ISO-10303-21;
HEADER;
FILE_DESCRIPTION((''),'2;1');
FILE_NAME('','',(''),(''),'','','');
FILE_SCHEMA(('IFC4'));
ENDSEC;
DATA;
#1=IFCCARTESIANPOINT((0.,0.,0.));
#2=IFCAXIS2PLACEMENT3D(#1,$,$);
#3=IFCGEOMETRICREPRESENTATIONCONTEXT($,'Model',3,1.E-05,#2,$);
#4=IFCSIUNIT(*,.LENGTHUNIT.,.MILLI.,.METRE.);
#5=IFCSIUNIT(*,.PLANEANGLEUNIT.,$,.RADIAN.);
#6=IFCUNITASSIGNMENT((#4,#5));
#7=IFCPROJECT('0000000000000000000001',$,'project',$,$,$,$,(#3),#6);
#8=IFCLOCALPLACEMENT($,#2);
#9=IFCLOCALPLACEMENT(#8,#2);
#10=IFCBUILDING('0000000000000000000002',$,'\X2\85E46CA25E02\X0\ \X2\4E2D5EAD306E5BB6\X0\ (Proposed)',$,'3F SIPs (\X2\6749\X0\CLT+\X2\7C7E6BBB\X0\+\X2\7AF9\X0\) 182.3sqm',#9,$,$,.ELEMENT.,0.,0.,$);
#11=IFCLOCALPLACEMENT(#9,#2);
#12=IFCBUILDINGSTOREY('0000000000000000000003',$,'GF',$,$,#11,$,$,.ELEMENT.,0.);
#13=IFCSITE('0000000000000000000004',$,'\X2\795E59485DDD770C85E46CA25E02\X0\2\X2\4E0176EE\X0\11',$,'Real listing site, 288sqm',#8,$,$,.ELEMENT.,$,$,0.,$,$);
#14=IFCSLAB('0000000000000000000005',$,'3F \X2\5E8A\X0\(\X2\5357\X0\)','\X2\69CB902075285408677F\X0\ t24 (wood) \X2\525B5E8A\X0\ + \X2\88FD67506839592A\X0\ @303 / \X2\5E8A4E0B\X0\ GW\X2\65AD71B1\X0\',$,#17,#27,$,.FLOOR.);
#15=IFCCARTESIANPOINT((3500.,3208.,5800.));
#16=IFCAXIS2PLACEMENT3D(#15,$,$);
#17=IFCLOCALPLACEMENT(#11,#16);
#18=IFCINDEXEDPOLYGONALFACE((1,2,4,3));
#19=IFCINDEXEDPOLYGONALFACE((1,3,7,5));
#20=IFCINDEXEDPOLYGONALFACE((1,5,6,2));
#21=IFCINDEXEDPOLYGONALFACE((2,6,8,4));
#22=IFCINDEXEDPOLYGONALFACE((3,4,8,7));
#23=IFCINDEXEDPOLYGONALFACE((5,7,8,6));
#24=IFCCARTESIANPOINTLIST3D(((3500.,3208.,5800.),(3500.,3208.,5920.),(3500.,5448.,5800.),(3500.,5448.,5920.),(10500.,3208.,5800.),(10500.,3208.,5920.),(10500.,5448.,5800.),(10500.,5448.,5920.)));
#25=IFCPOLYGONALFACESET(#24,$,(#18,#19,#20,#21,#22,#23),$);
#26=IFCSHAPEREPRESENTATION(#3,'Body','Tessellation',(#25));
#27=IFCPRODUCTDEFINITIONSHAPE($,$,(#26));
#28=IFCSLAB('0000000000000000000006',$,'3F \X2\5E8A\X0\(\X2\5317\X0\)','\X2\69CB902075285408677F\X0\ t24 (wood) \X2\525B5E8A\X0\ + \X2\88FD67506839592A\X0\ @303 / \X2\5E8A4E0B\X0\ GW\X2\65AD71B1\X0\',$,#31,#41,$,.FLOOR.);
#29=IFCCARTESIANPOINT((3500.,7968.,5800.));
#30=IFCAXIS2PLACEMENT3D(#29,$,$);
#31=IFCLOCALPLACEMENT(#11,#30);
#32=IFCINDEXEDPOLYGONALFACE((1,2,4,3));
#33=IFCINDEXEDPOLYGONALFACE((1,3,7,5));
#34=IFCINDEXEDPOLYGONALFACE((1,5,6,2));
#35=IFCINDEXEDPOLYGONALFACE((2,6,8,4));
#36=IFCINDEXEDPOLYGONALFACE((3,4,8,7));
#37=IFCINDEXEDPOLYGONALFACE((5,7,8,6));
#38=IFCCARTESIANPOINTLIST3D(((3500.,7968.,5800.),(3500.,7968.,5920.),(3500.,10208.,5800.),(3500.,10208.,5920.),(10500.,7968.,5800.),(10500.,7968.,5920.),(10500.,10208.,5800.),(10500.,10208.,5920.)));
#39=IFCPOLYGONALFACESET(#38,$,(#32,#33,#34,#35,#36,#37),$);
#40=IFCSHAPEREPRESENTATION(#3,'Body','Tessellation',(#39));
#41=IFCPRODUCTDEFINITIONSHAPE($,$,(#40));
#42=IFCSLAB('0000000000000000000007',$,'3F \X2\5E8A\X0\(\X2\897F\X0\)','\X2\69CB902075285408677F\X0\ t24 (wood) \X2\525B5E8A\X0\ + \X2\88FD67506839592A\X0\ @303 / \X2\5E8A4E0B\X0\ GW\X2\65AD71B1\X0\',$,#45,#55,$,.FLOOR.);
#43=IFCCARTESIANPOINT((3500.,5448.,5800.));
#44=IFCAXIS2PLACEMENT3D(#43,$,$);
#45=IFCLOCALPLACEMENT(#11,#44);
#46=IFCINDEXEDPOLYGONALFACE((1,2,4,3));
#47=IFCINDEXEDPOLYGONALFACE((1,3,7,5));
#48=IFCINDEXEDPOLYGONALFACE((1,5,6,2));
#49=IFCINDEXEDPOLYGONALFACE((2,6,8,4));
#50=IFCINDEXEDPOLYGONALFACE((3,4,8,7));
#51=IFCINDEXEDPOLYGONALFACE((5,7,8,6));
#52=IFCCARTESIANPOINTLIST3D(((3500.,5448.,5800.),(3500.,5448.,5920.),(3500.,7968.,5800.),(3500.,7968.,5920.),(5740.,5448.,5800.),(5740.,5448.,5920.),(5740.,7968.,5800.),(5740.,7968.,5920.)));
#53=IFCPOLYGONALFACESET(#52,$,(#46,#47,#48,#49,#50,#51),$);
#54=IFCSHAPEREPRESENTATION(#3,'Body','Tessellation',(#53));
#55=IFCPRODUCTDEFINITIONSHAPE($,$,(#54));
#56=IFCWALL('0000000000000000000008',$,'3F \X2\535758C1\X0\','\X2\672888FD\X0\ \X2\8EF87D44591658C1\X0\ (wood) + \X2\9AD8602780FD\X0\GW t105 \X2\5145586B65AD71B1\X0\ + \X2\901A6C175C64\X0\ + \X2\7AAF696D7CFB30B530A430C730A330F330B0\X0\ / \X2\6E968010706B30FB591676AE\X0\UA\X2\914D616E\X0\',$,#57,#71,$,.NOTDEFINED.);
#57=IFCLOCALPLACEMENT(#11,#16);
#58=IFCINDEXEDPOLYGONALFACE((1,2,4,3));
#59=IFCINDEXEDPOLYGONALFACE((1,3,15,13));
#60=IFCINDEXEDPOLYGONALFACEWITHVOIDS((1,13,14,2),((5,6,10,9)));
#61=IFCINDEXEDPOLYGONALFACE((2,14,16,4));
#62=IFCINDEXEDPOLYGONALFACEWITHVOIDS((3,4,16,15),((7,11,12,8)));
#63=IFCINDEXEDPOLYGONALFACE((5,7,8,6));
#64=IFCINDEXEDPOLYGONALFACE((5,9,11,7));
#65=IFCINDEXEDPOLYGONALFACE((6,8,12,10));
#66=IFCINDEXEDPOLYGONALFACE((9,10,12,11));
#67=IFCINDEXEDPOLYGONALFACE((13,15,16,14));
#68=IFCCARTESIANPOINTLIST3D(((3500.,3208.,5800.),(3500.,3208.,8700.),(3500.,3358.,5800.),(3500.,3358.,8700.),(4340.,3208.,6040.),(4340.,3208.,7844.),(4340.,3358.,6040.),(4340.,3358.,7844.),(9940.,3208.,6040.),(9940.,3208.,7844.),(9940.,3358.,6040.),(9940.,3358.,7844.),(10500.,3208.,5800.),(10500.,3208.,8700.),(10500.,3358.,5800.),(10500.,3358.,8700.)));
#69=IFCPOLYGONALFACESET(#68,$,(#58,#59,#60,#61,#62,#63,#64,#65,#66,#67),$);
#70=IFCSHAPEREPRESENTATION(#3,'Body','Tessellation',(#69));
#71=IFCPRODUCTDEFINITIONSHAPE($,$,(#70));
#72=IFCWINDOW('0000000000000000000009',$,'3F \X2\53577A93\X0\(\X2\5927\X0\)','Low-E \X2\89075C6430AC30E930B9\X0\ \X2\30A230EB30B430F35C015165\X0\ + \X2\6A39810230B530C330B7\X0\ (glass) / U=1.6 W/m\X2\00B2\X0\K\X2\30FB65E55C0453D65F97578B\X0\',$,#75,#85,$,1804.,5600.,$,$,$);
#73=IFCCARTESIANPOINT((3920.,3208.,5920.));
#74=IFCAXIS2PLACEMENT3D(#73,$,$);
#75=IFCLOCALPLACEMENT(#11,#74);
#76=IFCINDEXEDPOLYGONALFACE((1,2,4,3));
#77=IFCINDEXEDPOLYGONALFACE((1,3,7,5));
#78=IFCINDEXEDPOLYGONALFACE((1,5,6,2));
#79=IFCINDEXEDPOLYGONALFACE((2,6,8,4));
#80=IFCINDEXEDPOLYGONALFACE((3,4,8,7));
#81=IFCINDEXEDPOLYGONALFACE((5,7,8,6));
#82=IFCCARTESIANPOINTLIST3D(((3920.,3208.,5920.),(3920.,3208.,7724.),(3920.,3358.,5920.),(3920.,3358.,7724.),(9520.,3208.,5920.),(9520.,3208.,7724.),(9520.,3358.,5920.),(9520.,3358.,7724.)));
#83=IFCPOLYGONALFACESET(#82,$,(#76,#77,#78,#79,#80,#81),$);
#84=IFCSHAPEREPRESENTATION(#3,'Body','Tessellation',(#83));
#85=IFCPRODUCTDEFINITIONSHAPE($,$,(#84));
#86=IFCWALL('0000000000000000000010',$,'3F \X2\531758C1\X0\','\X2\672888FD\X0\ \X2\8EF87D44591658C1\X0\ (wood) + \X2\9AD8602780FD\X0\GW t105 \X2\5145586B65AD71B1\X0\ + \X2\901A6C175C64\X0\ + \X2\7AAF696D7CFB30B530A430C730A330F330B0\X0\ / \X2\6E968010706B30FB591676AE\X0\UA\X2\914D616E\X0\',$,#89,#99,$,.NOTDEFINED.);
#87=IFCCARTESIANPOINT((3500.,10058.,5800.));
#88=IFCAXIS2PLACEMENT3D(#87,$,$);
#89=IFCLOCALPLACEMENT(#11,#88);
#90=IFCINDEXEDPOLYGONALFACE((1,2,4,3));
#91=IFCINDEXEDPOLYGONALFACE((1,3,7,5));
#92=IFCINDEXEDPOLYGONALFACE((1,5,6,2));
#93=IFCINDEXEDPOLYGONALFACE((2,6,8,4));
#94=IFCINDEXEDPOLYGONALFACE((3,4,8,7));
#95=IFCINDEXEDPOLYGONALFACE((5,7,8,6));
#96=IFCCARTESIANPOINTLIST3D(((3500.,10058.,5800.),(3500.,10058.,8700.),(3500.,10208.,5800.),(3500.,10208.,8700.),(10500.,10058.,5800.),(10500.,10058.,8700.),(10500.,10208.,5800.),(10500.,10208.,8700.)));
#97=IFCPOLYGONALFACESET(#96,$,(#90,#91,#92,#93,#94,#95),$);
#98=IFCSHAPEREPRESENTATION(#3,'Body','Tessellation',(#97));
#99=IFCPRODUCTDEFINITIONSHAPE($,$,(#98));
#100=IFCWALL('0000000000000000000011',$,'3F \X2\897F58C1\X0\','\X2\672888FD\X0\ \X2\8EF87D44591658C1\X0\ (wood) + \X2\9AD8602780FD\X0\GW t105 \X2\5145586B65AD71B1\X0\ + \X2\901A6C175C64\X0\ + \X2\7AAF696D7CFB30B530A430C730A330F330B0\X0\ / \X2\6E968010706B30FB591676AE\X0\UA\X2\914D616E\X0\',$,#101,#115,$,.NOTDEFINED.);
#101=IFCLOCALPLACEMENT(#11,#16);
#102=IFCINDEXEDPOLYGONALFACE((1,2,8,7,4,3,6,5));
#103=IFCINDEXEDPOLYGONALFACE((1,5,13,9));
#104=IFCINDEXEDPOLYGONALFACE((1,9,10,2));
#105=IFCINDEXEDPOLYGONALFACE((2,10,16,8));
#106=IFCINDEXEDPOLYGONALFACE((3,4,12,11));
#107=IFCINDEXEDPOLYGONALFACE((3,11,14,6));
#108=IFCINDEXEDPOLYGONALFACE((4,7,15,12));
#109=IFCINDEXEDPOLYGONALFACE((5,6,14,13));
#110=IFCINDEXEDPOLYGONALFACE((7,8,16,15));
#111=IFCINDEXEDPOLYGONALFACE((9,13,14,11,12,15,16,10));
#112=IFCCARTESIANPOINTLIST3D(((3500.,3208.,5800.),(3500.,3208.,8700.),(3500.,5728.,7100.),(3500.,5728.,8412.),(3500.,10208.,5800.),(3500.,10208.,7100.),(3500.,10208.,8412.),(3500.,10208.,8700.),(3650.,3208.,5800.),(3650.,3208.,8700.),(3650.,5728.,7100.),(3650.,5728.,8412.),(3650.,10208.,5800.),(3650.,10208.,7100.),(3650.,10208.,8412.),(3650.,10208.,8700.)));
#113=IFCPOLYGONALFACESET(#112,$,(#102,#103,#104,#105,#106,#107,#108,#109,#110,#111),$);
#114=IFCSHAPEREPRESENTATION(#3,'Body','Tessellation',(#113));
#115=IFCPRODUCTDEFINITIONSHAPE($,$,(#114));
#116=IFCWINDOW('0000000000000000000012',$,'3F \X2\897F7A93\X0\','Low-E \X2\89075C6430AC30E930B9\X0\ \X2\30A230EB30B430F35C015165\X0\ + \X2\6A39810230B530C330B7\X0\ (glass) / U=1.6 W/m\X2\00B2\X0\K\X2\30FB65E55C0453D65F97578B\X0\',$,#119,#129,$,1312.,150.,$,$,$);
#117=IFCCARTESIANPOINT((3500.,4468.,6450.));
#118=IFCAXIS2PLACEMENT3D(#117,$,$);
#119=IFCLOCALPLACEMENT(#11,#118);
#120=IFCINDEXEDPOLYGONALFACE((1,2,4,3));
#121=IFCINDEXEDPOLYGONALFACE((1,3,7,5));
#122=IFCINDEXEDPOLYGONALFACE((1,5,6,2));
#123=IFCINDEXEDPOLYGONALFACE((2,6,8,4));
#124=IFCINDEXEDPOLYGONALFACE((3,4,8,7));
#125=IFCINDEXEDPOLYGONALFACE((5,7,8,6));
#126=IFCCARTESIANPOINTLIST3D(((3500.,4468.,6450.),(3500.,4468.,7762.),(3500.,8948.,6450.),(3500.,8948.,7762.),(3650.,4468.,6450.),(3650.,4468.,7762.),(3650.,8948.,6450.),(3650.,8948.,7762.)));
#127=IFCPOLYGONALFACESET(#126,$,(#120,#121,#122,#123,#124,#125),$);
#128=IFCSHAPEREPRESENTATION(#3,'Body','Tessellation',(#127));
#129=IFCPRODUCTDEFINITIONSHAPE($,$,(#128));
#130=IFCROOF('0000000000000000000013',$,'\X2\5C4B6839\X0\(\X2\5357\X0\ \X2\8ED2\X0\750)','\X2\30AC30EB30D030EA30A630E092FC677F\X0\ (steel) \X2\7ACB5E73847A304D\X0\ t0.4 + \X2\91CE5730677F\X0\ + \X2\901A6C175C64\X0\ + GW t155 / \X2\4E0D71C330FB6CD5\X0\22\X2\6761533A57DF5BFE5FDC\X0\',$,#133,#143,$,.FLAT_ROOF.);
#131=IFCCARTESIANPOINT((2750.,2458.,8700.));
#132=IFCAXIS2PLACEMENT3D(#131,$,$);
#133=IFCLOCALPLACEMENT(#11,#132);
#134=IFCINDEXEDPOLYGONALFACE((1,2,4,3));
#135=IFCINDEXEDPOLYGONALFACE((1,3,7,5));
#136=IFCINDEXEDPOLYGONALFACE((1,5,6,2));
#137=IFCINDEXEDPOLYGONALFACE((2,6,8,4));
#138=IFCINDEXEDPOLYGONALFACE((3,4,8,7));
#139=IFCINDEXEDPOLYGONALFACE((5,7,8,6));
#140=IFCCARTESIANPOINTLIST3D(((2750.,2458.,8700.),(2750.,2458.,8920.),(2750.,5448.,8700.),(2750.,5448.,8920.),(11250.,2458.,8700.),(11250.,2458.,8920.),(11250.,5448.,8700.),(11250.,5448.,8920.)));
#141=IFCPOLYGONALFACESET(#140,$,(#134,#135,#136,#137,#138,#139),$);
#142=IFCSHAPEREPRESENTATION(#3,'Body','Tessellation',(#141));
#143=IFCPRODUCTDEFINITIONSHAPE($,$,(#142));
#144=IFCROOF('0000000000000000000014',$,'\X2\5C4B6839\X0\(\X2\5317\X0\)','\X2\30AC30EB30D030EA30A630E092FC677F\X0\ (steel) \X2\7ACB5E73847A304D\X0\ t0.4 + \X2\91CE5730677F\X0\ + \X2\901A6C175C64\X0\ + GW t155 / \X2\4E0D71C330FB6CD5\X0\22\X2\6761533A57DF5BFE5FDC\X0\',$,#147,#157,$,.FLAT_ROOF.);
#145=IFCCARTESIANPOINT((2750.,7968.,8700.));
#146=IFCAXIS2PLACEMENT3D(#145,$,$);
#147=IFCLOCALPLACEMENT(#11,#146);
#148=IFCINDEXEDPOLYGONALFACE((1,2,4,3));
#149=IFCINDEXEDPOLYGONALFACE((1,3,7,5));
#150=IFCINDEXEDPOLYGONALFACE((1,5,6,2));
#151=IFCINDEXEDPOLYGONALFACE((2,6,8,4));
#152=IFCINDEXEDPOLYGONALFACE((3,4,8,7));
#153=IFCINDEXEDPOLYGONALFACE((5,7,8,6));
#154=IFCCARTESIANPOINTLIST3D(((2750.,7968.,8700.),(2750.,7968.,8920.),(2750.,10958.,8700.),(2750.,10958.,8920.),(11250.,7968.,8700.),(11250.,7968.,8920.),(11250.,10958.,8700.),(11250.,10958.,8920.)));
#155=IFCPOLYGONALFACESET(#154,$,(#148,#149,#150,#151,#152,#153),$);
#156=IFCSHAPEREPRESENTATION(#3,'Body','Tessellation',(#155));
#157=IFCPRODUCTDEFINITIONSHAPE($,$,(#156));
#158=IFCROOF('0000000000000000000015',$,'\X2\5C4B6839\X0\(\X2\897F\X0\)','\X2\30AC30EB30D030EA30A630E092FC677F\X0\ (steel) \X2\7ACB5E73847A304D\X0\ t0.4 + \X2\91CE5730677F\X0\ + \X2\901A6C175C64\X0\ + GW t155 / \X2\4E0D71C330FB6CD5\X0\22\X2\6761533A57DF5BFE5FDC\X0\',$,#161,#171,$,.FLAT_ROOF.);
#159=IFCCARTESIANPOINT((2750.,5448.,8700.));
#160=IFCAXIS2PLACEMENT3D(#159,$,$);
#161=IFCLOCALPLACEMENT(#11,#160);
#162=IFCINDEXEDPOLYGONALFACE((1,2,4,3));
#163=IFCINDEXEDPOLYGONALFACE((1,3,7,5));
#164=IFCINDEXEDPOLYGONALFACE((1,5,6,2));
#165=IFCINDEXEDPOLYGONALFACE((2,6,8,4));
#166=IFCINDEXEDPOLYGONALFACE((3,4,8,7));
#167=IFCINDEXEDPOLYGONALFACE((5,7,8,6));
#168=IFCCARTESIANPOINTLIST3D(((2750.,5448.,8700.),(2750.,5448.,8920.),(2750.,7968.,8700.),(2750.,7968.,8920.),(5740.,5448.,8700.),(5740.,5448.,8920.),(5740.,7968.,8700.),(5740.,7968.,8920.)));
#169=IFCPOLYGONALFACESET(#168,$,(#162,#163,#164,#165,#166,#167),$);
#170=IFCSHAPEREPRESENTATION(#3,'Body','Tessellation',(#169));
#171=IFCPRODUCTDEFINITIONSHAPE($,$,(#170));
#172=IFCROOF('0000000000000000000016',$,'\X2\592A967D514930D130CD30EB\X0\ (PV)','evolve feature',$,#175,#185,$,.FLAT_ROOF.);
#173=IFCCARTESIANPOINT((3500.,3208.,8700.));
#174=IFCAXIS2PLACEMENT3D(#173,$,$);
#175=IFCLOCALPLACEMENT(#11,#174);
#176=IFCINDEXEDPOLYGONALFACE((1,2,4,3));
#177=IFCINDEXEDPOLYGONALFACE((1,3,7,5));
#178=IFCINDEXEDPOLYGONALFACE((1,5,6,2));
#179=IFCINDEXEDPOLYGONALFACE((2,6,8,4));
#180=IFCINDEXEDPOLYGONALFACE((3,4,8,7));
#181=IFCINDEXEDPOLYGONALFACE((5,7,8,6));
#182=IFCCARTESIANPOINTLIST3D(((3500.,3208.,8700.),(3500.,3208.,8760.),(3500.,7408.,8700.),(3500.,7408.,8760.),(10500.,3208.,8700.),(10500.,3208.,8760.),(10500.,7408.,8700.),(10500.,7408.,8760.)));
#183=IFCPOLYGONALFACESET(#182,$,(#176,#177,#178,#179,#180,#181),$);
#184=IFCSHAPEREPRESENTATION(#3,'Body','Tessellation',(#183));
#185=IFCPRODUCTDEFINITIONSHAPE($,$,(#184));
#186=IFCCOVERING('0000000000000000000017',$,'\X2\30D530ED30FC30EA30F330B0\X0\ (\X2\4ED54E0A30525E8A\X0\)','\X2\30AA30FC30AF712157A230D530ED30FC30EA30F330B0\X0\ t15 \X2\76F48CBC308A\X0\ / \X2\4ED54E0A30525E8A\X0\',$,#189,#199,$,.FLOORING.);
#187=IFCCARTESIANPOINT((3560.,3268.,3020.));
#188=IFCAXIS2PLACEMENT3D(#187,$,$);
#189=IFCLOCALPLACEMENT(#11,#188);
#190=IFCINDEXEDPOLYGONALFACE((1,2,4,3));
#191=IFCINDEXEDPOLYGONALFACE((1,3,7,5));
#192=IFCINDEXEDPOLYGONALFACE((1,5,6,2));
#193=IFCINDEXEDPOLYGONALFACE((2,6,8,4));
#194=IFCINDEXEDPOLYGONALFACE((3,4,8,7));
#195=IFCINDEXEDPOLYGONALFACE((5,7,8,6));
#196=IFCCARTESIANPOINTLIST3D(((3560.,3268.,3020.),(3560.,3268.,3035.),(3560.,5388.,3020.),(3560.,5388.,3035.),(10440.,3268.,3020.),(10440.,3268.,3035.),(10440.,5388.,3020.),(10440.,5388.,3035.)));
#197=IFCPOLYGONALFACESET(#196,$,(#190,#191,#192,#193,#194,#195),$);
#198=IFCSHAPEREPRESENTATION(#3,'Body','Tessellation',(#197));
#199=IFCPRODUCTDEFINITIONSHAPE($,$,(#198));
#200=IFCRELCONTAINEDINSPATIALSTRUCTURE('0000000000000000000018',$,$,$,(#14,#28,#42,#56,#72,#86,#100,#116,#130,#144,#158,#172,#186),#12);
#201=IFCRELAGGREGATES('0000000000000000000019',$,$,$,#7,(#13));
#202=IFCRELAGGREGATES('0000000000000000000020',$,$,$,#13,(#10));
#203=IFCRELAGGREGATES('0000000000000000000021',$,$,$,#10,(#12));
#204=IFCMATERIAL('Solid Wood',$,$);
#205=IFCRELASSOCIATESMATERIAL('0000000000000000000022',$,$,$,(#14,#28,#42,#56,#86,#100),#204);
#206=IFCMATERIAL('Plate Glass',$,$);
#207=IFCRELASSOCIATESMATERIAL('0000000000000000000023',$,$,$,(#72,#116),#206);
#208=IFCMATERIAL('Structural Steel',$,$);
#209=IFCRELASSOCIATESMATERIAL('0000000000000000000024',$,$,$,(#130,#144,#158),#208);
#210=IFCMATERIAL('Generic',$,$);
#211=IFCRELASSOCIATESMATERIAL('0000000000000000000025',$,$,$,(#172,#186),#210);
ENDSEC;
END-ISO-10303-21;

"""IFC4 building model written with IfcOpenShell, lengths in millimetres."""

from ifc_helpers import new_model, si_unit, frame, frame_2d, origin, place, context, project, spatial, rectangle, extrude, material, element, fill, save


model = new_model("IFC4")

# Units and contexts
model_context = context("Model", 3, precision=1e-05, world=origin())
ifc_project = project(units=[si_unit("LENGTHUNIT", "METRE", prefix="MILLI"), si_unit("PLANEANGLEUNIT", "RADIAN")], contexts=[model_context])

# Site, building, storey
site_placement = place(None, origin())
site = spatial("IfcSite", under=ifc_project, at=site_placement, Name="神奈川県藤沢市2丁目11", ObjectType="Real listing site, 288sqm", CompositionType="ELEMENT", RefElevation=0.0)
building_placement = place(site_placement, origin())
building = spatial("IfcBuilding", under=site, at=building_placement, Name="藤沢市 中庭の家 (Proposed)", ObjectType="3F SIPs (杉CLT+籾殻+竹) 182.3sqm", CompositionType="ELEMENT", ElevationOfRefHeight=0.0, ElevationOfTerrain=0.0)
storey_placement = place(building_placement, origin())
storey = spatial("IfcBuildingStorey", under=building, at=storey_placement, Name="GF", CompositionType="ELEMENT", Elevation=0.0)

# Slabs
ifc_material_1 = material(Name="Solid Wood")
slab_1_placement = place(storey_placement, frame((3500.0, 3208.0, 5800.0)))
element("IfcSlab", 1, at=slab_1_placement, inside=storey, material=ifc_material_1, Name="3F 床(南)", Description="構造用合板 t24 (wood) 剛床 + 製材根太 @303 / 床下 GW断熱", PredefinedType="FLOOR", context=model_context, shape_type="SweptSolid", body=[
    extrude(rectangle(XDim=7000.0, YDim=2240.0, at=frame_2d((3500.0, 1120.0))), frame((3500.0, 3208.0, 5800.0)), (0.0, 0.0, 1.0), 120.0),
])
slab_2_placement = place(storey_placement, frame((3500.0, 7968.0, 5800.0)))
element("IfcSlab", 2, at=slab_2_placement, inside=storey, material=ifc_material_1, Name="3F 床(北)", Description="構造用合板 t24 (wood) 剛床 + 製材根太 @303 / 床下 GW断熱", PredefinedType="FLOOR", context=model_context, shape_type="SweptSolid", body=[
    extrude(rectangle(XDim=7000.0, YDim=2240.0, at=frame_2d((3500.0, 1120.0))), frame((3500.0, 7968.0, 5800.0)), (0.0, 0.0, 1.0), 120.0),
])
slab_3_placement = place(storey_placement, frame((3500.0, 5448.0, 5800.0)))
element("IfcSlab", 3, at=slab_3_placement, inside=storey, material=ifc_material_1, Name="3F 床(西)", Description="構造用合板 t24 (wood) 剛床 + 製材根太 @303 / 床下 GW断熱", PredefinedType="FLOOR", context=model_context, shape_type="SweptSolid", body=[
    extrude(rectangle(XDim=2240.0, YDim=2520.0, at=frame_2d((1120.0, 1260.0))), frame((3500.0, 5448.0, 5800.0)), (0.0, 0.0, 1.0), 120.0),
])

# Wall, opening, window
wall_1_placement = place(storey_placement, frame((3500.0, 3208.0, 5800.0)))
wall_1 = element("IfcWall", 4, at=wall_1_placement, inside=storey, material=ifc_material_1, Name="3F 南壁", Description="木製 軸組外壁 (wood) + 高性能GW t105 充填断熱 + 通気層 + 窯業系サイディング / 準耐火・外皮UA配慮", PredefinedType="NOTDEFINED", context=model_context, shape_type="SweptSolid", body=[
    extrude(rectangle(XDim=7000.0, YDim=150.0, at=frame_2d((3500.0, 75.0))), frame((3500.0, 3208.0, 5800.0)), (0.0, 0.0, 1.0), 2900.0),
])
opening_1_placement = place(storey_placement, frame((3920.0, 3208.0, 5920.0)))
opening_1 = element("IfcOpeningElement", 5, at=opening_1_placement, cuts=wall_1, PredefinedType="NOTDEFINED", context=model_context, shape_type="SweptSolid", body=[
    extrude(rectangle(XDim=5600.0, YDim=150.0, at=frame_2d((2800.0, 75.0))), frame((3920.0, 3208.0, 5920.0)), (0.0, 0.0, 1.0), 1804.0),
])
ifc_material_2 = material(Name="Plate Glass")
window_1_placement = place(storey_placement, frame((3920.0, 3208.0, 5920.0)))
window_1 = element("IfcWindow", 6, at=window_1_placement, inside=storey, material=ifc_material_2, Name="3F 南窓(大)", Description="Low-E 複層ガラス アルゴン封入 + 樹脂サッシ (glass) / U=1.6 W/m²K・日射取得型", OverallHeight=1804.0, OverallWidth=5600.0, context=model_context, shape_type="SweptSolid", body=[
    extrude(rectangle(XDim=5600.0, YDim=150.0, at=frame_2d((2800.0, 75.0))), frame((3920.0, 3208.0, 5920.0)), (0.0, 0.0, 1.0), 1804.0),
])
fill(opening_1, window_1)

# Wall
wall_2_placement = place(storey_placement, frame((3500.0, 10058.0, 5800.0)))
element("IfcWall", 7, at=wall_2_placement, inside=storey, material=ifc_material_1, Name="3F 北壁", Description="木製 軸組外壁 (wood) + 高性能GW t105 充填断熱 + 通気層 + 窯業系サイディング / 準耐火・外皮UA配慮", PredefinedType="NOTDEFINED", context=model_context, shape_type="SweptSolid", body=[
    extrude(rectangle(XDim=7000.0, YDim=150.0, at=frame_2d((3500.0, 75.0))), frame((3500.0, 10058.0, 5800.0)), (0.0, 0.0, 1.0), 2900.0),
])

# Wall, opening, window
wall_3_placement = place(storey_placement, frame((3500.0, 3208.0, 5800.0)))
wall_3 = element("IfcWall", 8, at=wall_3_placement, inside=storey, material=ifc_material_1, Name="3F 西壁", Description="木製 軸組外壁 (wood) + 高性能GW t105 充填断熱 + 通気層 + 窯業系サイディング / 準耐火・外皮UA配慮", PredefinedType="NOTDEFINED", context=model_context, shape_type="SweptSolid", body=[
    extrude(rectangle(XDim=150.0, YDim=7000.0, at=frame_2d((75.0, 3500.0))), frame((3500.0, 3208.0, 5800.0)), (0.0, 0.0, 1.0), 2900.0),
])
opening_2_placement = place(storey_placement, frame((3500.0, 4468.0, 6450.0)))
opening_2 = element("IfcOpeningElement", 9, at=opening_2_placement, cuts=wall_3, PredefinedType="NOTDEFINED", context=model_context, shape_type="SweptSolid", body=[
    extrude(rectangle(XDim=150.0, YDim=4480.0, at=frame_2d((75.0, 2240.0))), frame((3500.0, 4468.0, 6450.0)), (0.0, 0.0, 1.0), 1312.0),
])
window_2_placement = place(storey_placement, frame((3500.0, 4468.0, 6450.0)))
window_2 = element("IfcWindow", 10, at=window_2_placement, inside=storey, material=ifc_material_2, Name="3F 西窓", Description="Low-E 複層ガラス アルゴン封入 + 樹脂サッシ (glass) / U=1.6 W/m²K・日射取得型", OverallHeight=1312.0, OverallWidth=150.0, context=model_context, shape_type="SweptSolid", body=[
    extrude(rectangle(XDim=150.0, YDim=4480.0, at=frame_2d((75.0, 2240.0))), frame((3500.0, 4468.0, 6450.0)), (0.0, 0.0, 1.0), 1312.0),
])
fill(opening_2, window_2)

# Roofs
ifc_material_3 = material(Name="Structural Steel")
roof_1_placement = place(storey_placement, frame((2750.0, 2458.0, 8700.0)))
element("IfcRoof", 11, at=roof_1_placement, inside=storey, material=ifc_material_3, Name="屋根(南 軒750)", Description="ガルバリウム鋼板 (steel) 立平葺き t0.4 + 野地板 + 通気層 + GW t155 / 不燃・法22条区域対応", PredefinedType="FLAT_ROOF", context=model_context, shape_type="SweptSolid", body=[
    extrude(rectangle(XDim=8500.0, YDim=2990.0, at=frame_2d((4250.0, 1495.0))), frame((2750.0, 2458.0, 8700.0)), (0.0, 0.0, 1.0), 220.0),
])
roof_2_placement = place(storey_placement, frame((2750.0, 7968.0, 8700.0)))
element("IfcRoof", 12, at=roof_2_placement, inside=storey, material=ifc_material_3, Name="屋根(北)", Description="ガルバリウム鋼板 (steel) 立平葺き t0.4 + 野地板 + 通気層 + GW t155 / 不燃・法22条区域対応", PredefinedType="FLAT_ROOF", context=model_context, shape_type="SweptSolid", body=[
    extrude(rectangle(XDim=8500.0, YDim=2990.0, at=frame_2d((4250.0, 1495.0))), frame((2750.0, 7968.0, 8700.0)), (0.0, 0.0, 1.0), 220.0),
])
roof_3_placement = place(storey_placement, frame((2750.0, 5448.0, 8700.0)))
element("IfcRoof", 13, at=roof_3_placement, inside=storey, material=ifc_material_3, Name="屋根(西)", Description="ガルバリウム鋼板 (steel) 立平葺き t0.4 + 野地板 + 通気層 + GW t155 / 不燃・法22条区域対応", PredefinedType="FLAT_ROOF", context=model_context, shape_type="SweptSolid", body=[
    extrude(rectangle(XDim=2990.0, YDim=2520.0, at=frame_2d((1495.0, 1260.0))), frame((2750.0, 5448.0, 8700.0)), (0.0, 0.0, 1.0), 220.0),
])
ifc_material_4 = material(Name="Generic")
roof_4_placement = place(storey_placement, frame((3500.0, 3208.0, 8700.0)))
element("IfcRoof", 14, at=roof_4_placement, inside=storey, material=ifc_material_4, Name="太陽光パネル (PV)", Description="evolve feature", PredefinedType="FLAT_ROOF", context=model_context, shape_type="SweptSolid", body=[
    extrude(rectangle(XDim=7000.0, YDim=4200.0, at=frame_2d((3500.0, 2100.0))), frame((3500.0, 3208.0, 8700.0)), (0.0, 0.0, 1.0), 60.0),
])

# Covering
covering_1_placement = place(storey_placement, frame((3560.0, 3268.0, 3020.0)))
element("IfcCovering", 15, at=covering_1_placement, inside=storey, material=ifc_material_4, Name="フローリング (仕上げ床)", Description="オーク無垢フローリング t15 直貼り / 仕上げ床", PredefinedType="FLOORING", context=model_context, shape_type="SweptSolid", body=[
    extrude(rectangle(XDim=6880.0, YDim=2120.0, at=frame_2d((3440.0, 1060.0))), frame((3560.0, 3268.0, 3020.0)), (0.0, 0.0, 1.0), 15.0),
])

save(model, "model.ifc")
